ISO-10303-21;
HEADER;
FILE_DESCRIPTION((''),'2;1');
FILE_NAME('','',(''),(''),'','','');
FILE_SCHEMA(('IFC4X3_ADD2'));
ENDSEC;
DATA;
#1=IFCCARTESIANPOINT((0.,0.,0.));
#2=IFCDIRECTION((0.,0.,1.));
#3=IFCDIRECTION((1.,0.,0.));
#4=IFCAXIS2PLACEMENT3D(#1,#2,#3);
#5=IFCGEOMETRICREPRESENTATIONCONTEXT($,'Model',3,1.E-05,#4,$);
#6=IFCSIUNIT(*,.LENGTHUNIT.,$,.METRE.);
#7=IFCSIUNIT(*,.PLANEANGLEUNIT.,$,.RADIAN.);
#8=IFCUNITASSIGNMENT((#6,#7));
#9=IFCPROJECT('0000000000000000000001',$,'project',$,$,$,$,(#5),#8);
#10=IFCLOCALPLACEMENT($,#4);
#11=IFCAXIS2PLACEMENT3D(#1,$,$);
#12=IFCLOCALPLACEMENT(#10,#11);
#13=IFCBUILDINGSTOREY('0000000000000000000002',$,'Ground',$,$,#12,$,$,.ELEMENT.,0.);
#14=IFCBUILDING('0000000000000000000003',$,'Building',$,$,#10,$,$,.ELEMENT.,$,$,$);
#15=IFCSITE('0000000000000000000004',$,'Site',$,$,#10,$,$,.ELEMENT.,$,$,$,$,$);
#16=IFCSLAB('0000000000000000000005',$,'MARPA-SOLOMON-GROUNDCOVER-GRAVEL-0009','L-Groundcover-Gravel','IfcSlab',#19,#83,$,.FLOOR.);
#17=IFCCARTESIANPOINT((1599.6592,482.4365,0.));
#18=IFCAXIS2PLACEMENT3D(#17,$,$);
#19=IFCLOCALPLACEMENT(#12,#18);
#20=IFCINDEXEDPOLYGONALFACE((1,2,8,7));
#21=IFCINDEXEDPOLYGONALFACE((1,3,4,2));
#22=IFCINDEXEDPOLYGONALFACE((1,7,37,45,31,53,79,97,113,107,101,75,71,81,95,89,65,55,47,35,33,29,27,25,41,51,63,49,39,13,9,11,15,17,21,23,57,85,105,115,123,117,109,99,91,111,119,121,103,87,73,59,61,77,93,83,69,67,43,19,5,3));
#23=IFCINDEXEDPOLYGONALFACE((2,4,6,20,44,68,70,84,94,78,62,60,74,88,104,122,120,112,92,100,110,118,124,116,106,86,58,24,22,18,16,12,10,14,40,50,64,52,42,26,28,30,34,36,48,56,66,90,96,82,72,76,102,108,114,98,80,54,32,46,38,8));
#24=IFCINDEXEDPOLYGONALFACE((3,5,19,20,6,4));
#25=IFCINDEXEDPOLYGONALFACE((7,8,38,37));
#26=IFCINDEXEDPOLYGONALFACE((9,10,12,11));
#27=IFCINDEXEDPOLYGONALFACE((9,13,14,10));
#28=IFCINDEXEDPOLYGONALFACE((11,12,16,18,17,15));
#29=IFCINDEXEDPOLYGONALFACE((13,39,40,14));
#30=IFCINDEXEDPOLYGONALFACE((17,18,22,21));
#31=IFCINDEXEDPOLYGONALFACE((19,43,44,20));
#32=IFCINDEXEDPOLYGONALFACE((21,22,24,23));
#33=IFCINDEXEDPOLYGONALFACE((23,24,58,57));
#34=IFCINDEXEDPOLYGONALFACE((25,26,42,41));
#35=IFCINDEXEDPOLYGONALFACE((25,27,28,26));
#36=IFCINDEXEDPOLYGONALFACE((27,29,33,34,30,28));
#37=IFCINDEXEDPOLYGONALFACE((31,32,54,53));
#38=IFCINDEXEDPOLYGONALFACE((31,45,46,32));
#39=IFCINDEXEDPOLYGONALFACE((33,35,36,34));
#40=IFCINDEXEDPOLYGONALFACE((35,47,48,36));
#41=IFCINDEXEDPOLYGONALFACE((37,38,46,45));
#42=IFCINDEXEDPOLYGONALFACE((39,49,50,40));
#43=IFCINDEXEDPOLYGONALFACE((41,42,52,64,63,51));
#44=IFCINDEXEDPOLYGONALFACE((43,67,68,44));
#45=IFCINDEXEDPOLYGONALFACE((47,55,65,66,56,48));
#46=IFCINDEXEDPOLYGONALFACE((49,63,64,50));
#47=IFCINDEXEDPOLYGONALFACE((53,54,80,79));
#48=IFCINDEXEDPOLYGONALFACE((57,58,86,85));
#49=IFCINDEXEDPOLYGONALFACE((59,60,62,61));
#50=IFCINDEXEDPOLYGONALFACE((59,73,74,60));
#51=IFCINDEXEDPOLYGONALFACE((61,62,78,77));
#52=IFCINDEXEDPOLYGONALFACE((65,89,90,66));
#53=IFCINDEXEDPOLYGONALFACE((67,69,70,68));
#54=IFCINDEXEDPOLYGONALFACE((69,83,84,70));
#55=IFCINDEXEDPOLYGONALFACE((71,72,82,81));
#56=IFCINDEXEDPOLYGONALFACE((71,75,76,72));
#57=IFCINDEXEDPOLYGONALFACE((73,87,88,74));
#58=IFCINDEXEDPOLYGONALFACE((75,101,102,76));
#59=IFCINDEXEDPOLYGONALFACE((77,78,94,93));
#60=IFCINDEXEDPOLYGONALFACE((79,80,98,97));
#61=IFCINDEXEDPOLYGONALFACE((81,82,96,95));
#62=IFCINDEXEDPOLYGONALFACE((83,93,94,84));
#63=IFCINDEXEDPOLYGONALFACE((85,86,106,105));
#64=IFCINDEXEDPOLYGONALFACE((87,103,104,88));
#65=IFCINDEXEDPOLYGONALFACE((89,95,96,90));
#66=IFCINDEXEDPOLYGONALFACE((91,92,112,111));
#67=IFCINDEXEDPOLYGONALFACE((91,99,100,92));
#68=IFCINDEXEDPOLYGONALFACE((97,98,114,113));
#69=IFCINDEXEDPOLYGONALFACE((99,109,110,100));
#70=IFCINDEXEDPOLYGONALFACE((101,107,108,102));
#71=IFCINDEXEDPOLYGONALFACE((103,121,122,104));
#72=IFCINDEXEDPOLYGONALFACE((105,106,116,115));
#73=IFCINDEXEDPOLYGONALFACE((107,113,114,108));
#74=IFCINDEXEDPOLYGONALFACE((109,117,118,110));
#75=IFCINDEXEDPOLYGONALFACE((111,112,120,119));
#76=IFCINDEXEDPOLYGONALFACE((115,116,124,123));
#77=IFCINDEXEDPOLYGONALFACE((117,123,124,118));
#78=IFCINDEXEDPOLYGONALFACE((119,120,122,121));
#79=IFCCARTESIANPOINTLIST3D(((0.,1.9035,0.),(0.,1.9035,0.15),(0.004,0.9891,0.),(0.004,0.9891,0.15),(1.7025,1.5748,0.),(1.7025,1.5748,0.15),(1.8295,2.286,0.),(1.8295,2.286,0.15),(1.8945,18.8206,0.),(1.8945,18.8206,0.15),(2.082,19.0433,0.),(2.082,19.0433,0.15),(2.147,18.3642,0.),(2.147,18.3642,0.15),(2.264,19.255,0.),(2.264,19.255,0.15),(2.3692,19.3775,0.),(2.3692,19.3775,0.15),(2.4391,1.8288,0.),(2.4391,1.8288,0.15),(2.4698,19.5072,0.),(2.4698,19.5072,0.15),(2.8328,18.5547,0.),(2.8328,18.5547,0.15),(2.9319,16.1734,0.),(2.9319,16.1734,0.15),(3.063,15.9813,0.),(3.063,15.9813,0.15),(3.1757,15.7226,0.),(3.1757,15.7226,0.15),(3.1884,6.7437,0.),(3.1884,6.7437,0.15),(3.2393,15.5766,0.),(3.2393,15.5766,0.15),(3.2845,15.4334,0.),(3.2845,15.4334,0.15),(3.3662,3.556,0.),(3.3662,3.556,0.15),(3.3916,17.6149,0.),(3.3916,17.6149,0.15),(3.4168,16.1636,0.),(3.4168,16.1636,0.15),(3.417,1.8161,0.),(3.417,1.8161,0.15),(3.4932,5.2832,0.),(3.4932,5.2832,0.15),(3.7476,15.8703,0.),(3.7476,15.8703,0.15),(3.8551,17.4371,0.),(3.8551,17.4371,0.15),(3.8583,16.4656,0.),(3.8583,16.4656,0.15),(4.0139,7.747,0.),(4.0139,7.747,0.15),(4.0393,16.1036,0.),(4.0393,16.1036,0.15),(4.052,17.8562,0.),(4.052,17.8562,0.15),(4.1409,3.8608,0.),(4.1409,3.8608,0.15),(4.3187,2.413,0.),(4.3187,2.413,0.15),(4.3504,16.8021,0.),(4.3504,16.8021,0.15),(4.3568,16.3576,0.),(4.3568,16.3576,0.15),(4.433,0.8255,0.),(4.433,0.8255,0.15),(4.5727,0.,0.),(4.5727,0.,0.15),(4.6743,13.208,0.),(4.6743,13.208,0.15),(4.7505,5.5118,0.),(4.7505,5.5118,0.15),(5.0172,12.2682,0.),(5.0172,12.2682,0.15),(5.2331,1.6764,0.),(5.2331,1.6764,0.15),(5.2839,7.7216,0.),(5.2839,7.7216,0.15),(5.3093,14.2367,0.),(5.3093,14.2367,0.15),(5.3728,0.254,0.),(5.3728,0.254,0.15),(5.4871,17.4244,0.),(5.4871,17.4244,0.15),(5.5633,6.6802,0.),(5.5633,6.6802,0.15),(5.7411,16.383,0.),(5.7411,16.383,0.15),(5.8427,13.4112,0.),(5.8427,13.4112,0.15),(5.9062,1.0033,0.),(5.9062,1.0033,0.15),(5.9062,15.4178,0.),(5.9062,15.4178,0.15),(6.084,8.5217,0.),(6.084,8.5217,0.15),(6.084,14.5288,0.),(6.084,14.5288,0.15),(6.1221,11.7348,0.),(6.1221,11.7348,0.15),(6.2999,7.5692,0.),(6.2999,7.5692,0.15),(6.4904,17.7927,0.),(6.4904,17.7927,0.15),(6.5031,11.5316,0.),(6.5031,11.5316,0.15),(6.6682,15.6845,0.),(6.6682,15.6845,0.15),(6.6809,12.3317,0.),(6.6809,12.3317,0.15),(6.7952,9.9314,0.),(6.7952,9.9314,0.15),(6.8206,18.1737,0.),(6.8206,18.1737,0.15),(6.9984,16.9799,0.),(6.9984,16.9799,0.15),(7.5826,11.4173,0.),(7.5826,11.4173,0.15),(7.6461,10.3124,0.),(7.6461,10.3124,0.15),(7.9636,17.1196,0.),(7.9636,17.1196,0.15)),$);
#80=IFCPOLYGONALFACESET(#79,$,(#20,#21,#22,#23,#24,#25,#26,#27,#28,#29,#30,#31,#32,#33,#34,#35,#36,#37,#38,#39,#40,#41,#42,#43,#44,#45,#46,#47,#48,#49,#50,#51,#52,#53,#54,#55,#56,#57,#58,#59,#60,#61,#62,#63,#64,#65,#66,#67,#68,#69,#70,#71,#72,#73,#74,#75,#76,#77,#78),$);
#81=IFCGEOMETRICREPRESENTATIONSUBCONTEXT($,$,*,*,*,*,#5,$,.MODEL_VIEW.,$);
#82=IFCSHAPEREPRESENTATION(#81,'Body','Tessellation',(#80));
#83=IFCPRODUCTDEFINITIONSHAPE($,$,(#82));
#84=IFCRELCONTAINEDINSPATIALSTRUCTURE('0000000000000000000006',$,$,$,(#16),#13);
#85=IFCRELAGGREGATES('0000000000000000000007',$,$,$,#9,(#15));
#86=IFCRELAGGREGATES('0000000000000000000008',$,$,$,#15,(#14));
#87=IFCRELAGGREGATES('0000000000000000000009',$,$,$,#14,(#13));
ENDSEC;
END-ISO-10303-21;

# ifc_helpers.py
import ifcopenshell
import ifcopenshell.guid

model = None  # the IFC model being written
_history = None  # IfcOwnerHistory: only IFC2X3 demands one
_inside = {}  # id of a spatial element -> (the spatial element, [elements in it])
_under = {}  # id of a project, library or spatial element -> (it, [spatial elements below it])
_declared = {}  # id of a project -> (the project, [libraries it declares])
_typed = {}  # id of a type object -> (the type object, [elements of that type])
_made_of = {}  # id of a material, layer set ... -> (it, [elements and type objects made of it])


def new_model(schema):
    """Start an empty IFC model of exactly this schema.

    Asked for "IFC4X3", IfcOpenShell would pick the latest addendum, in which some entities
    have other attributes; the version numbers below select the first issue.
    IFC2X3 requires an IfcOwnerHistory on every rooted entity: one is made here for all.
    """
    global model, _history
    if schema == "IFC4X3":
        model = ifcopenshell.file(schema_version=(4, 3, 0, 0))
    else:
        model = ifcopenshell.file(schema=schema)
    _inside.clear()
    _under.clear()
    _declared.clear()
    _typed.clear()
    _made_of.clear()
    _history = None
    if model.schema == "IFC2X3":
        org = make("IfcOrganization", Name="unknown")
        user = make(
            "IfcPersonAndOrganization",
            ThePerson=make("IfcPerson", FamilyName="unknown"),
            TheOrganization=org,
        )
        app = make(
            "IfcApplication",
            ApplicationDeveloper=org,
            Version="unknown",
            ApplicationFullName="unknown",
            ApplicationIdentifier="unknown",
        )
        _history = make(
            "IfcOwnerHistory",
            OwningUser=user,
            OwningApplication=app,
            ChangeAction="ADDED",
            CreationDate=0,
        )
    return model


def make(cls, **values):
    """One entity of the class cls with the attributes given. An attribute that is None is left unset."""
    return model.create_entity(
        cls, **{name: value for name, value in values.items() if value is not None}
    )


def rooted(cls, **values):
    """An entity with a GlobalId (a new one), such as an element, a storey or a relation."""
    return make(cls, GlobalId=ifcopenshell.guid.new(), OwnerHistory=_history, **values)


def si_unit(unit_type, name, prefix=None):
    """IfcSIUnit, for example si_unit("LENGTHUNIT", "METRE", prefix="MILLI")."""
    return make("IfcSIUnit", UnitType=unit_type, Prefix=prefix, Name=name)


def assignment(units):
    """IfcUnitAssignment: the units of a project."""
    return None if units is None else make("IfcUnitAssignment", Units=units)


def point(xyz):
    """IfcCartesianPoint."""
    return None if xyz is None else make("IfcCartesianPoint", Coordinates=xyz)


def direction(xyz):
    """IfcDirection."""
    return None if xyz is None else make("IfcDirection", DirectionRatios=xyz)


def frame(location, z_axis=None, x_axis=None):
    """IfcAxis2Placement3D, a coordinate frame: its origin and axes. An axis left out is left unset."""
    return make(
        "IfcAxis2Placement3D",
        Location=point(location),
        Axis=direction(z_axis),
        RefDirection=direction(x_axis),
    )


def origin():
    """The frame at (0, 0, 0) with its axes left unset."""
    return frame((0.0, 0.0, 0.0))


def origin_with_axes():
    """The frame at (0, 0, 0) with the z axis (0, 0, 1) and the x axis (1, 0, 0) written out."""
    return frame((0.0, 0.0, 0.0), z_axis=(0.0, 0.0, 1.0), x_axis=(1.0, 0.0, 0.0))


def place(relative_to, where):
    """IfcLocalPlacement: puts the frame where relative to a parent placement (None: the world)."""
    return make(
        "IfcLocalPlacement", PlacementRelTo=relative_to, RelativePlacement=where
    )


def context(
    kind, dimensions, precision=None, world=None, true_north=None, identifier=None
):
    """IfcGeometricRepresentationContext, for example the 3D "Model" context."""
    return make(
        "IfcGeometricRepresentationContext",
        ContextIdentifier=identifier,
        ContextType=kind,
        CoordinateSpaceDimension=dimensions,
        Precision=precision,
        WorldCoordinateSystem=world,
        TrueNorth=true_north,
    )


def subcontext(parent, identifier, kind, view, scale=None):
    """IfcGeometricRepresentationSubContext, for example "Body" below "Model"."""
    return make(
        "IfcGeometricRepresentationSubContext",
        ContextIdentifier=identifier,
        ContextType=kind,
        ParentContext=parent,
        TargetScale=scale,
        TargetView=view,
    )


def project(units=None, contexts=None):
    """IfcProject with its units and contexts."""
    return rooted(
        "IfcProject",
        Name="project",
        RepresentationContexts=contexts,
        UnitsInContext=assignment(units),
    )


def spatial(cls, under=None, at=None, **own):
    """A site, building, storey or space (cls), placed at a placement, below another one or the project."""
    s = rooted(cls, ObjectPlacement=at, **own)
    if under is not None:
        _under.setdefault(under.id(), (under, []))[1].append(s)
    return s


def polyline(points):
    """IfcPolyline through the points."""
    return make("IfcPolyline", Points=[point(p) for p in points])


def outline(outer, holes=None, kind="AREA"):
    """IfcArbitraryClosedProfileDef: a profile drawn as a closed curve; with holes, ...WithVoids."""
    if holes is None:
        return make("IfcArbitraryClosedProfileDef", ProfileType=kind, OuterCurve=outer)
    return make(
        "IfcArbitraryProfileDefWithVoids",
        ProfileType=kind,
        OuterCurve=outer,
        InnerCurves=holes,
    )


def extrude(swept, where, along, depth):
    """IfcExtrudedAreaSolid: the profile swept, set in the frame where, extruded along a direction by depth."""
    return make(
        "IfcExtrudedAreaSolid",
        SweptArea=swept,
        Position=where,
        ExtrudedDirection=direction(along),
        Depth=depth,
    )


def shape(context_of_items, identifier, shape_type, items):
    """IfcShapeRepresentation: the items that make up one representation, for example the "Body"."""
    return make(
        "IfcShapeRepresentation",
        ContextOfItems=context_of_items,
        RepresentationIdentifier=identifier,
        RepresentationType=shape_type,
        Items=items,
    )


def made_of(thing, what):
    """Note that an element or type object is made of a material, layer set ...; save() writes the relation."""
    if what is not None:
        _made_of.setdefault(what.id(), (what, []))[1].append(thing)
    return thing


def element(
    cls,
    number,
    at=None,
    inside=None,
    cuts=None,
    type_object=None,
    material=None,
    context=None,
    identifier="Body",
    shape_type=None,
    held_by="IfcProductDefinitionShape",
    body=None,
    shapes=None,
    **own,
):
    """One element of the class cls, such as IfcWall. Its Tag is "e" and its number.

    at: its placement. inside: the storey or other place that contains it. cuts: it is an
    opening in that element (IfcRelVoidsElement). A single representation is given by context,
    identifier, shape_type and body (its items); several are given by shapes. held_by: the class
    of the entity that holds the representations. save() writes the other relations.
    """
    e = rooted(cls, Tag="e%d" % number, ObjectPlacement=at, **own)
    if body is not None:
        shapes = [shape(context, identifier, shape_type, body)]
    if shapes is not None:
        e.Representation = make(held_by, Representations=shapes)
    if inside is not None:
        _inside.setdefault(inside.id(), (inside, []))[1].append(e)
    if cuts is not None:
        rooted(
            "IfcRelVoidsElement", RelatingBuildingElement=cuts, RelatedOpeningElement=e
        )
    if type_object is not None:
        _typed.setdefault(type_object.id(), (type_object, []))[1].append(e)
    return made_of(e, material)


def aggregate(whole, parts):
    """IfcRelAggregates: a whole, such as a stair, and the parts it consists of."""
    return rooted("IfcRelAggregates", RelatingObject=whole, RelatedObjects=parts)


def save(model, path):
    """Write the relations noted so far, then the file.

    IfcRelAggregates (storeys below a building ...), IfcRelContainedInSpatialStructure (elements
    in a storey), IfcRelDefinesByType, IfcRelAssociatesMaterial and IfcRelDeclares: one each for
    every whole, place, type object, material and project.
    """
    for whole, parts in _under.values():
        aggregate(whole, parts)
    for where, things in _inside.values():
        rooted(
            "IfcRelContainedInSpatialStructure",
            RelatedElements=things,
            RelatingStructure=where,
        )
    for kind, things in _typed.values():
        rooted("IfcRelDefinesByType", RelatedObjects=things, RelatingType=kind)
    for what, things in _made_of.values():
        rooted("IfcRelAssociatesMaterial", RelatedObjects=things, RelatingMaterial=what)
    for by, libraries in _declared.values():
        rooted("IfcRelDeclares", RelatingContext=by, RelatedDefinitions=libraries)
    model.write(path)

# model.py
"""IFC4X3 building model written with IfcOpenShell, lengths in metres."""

from ifc_helpers import new_model, si_unit, frame, origin, origin_with_axes, place, context, subcontext, project, spatial, polyline, outline, extrude, element, save


model = new_model("IFC4X3")

# Units and contexts
model_context = context("Model", 3, precision=1e-05, world=origin_with_axes())
sub_context = subcontext(model_context, None, None, "MODEL_VIEW")
ifc_project = project(units=[si_unit("LENGTHUNIT", "METRE"), si_unit("PLANEANGLEUNIT", "RADIAN")], contexts=[model_context])

# Site, building, storey
placement = place(None, origin_with_axes())
site = spatial("IfcSite", under=ifc_project, at=placement, Name="Site", CompositionType="ELEMENT")
building = spatial("IfcBuilding", under=site, at=placement, Name="Building", CompositionType="ELEMENT")
storey_placement = place(placement, origin())
storey = spatial("IfcBuildingStorey", under=building, at=storey_placement, Name="Ground", CompositionType="ELEMENT", Elevation=0.0)

# Slab
slab_1_placement = place(storey_placement, frame((1599.6592, 482.4365, 0.0)))
element("IfcSlab", 1, at=slab_1_placement, inside=storey, Name="MARPA-SOLOMON-GROUNDCOVER-GRAVEL-0009", Description="L-Groundcover-Gravel", ObjectType="IfcSlab", PredefinedType="FLOOR", context=sub_context, shape_type="SweptSolid", body=[
    extrude(outline(polyline([(2.9319, 16.1734), (3.063, 15.9813), (3.1757, 15.7226), (3.2393, 15.5766), (3.2845, 15.4334), (3.7476, 15.8703), (4.0393, 16.1036), (4.3568, 16.3576), (5.7411, 16.383), (5.9062, 15.4178), (5.3093, 14.2367), (4.6743, 13.208), (5.0172, 12.2682), (6.1221, 11.7348), (6.5031, 11.5316), (6.7952, 9.9314), (6.084, 8.5217), (5.2839, 7.7216), (4.0139, 7.747), (3.1884, 6.7437), (3.4932, 5.2832), (3.3662, 3.556), (1.8295, 2.286), (0.0, 1.9035), (0.004, 0.9891), (1.7025, 1.5748), (2.4391, 1.8288), (3.417, 1.8161), (4.433, 0.8255), (4.5727, 0.0), (5.3728, 0.254), (5.9062, 1.0033), (5.2331, 1.6764), (4.3187, 2.413), (4.1409, 3.8608), (4.7505, 5.5118), (5.5633, 6.6802), (6.2999, 7.5692), (7.6461, 10.3124), (7.5826, 11.4173), (6.6809, 12.3317), (5.8427, 13.4112), (6.084, 14.5288), (6.6682, 15.6845), (6.9984, 16.9799), (7.9636, 17.1196), (6.8206, 18.1737), (6.4904, 17.7927), (5.4871, 17.4244), (4.052, 17.8562), (2.8328, 18.5547), (2.4698, 19.5072), (2.3692, 19.3775), (2.264, 19.255), (2.082, 19.0433), (1.8945, 18.8206), (2.147, 18.3642), (3.3916, 17.6149), (3.8551, 17.4371), (4.3504, 16.8021), (3.8583, 16.4656), (3.4168, 16.1636), (2.9319, 16.1734)])), origin(), (0.0, 0.0, 1.0), 0.15),
])

save(model, "model.ifc")
